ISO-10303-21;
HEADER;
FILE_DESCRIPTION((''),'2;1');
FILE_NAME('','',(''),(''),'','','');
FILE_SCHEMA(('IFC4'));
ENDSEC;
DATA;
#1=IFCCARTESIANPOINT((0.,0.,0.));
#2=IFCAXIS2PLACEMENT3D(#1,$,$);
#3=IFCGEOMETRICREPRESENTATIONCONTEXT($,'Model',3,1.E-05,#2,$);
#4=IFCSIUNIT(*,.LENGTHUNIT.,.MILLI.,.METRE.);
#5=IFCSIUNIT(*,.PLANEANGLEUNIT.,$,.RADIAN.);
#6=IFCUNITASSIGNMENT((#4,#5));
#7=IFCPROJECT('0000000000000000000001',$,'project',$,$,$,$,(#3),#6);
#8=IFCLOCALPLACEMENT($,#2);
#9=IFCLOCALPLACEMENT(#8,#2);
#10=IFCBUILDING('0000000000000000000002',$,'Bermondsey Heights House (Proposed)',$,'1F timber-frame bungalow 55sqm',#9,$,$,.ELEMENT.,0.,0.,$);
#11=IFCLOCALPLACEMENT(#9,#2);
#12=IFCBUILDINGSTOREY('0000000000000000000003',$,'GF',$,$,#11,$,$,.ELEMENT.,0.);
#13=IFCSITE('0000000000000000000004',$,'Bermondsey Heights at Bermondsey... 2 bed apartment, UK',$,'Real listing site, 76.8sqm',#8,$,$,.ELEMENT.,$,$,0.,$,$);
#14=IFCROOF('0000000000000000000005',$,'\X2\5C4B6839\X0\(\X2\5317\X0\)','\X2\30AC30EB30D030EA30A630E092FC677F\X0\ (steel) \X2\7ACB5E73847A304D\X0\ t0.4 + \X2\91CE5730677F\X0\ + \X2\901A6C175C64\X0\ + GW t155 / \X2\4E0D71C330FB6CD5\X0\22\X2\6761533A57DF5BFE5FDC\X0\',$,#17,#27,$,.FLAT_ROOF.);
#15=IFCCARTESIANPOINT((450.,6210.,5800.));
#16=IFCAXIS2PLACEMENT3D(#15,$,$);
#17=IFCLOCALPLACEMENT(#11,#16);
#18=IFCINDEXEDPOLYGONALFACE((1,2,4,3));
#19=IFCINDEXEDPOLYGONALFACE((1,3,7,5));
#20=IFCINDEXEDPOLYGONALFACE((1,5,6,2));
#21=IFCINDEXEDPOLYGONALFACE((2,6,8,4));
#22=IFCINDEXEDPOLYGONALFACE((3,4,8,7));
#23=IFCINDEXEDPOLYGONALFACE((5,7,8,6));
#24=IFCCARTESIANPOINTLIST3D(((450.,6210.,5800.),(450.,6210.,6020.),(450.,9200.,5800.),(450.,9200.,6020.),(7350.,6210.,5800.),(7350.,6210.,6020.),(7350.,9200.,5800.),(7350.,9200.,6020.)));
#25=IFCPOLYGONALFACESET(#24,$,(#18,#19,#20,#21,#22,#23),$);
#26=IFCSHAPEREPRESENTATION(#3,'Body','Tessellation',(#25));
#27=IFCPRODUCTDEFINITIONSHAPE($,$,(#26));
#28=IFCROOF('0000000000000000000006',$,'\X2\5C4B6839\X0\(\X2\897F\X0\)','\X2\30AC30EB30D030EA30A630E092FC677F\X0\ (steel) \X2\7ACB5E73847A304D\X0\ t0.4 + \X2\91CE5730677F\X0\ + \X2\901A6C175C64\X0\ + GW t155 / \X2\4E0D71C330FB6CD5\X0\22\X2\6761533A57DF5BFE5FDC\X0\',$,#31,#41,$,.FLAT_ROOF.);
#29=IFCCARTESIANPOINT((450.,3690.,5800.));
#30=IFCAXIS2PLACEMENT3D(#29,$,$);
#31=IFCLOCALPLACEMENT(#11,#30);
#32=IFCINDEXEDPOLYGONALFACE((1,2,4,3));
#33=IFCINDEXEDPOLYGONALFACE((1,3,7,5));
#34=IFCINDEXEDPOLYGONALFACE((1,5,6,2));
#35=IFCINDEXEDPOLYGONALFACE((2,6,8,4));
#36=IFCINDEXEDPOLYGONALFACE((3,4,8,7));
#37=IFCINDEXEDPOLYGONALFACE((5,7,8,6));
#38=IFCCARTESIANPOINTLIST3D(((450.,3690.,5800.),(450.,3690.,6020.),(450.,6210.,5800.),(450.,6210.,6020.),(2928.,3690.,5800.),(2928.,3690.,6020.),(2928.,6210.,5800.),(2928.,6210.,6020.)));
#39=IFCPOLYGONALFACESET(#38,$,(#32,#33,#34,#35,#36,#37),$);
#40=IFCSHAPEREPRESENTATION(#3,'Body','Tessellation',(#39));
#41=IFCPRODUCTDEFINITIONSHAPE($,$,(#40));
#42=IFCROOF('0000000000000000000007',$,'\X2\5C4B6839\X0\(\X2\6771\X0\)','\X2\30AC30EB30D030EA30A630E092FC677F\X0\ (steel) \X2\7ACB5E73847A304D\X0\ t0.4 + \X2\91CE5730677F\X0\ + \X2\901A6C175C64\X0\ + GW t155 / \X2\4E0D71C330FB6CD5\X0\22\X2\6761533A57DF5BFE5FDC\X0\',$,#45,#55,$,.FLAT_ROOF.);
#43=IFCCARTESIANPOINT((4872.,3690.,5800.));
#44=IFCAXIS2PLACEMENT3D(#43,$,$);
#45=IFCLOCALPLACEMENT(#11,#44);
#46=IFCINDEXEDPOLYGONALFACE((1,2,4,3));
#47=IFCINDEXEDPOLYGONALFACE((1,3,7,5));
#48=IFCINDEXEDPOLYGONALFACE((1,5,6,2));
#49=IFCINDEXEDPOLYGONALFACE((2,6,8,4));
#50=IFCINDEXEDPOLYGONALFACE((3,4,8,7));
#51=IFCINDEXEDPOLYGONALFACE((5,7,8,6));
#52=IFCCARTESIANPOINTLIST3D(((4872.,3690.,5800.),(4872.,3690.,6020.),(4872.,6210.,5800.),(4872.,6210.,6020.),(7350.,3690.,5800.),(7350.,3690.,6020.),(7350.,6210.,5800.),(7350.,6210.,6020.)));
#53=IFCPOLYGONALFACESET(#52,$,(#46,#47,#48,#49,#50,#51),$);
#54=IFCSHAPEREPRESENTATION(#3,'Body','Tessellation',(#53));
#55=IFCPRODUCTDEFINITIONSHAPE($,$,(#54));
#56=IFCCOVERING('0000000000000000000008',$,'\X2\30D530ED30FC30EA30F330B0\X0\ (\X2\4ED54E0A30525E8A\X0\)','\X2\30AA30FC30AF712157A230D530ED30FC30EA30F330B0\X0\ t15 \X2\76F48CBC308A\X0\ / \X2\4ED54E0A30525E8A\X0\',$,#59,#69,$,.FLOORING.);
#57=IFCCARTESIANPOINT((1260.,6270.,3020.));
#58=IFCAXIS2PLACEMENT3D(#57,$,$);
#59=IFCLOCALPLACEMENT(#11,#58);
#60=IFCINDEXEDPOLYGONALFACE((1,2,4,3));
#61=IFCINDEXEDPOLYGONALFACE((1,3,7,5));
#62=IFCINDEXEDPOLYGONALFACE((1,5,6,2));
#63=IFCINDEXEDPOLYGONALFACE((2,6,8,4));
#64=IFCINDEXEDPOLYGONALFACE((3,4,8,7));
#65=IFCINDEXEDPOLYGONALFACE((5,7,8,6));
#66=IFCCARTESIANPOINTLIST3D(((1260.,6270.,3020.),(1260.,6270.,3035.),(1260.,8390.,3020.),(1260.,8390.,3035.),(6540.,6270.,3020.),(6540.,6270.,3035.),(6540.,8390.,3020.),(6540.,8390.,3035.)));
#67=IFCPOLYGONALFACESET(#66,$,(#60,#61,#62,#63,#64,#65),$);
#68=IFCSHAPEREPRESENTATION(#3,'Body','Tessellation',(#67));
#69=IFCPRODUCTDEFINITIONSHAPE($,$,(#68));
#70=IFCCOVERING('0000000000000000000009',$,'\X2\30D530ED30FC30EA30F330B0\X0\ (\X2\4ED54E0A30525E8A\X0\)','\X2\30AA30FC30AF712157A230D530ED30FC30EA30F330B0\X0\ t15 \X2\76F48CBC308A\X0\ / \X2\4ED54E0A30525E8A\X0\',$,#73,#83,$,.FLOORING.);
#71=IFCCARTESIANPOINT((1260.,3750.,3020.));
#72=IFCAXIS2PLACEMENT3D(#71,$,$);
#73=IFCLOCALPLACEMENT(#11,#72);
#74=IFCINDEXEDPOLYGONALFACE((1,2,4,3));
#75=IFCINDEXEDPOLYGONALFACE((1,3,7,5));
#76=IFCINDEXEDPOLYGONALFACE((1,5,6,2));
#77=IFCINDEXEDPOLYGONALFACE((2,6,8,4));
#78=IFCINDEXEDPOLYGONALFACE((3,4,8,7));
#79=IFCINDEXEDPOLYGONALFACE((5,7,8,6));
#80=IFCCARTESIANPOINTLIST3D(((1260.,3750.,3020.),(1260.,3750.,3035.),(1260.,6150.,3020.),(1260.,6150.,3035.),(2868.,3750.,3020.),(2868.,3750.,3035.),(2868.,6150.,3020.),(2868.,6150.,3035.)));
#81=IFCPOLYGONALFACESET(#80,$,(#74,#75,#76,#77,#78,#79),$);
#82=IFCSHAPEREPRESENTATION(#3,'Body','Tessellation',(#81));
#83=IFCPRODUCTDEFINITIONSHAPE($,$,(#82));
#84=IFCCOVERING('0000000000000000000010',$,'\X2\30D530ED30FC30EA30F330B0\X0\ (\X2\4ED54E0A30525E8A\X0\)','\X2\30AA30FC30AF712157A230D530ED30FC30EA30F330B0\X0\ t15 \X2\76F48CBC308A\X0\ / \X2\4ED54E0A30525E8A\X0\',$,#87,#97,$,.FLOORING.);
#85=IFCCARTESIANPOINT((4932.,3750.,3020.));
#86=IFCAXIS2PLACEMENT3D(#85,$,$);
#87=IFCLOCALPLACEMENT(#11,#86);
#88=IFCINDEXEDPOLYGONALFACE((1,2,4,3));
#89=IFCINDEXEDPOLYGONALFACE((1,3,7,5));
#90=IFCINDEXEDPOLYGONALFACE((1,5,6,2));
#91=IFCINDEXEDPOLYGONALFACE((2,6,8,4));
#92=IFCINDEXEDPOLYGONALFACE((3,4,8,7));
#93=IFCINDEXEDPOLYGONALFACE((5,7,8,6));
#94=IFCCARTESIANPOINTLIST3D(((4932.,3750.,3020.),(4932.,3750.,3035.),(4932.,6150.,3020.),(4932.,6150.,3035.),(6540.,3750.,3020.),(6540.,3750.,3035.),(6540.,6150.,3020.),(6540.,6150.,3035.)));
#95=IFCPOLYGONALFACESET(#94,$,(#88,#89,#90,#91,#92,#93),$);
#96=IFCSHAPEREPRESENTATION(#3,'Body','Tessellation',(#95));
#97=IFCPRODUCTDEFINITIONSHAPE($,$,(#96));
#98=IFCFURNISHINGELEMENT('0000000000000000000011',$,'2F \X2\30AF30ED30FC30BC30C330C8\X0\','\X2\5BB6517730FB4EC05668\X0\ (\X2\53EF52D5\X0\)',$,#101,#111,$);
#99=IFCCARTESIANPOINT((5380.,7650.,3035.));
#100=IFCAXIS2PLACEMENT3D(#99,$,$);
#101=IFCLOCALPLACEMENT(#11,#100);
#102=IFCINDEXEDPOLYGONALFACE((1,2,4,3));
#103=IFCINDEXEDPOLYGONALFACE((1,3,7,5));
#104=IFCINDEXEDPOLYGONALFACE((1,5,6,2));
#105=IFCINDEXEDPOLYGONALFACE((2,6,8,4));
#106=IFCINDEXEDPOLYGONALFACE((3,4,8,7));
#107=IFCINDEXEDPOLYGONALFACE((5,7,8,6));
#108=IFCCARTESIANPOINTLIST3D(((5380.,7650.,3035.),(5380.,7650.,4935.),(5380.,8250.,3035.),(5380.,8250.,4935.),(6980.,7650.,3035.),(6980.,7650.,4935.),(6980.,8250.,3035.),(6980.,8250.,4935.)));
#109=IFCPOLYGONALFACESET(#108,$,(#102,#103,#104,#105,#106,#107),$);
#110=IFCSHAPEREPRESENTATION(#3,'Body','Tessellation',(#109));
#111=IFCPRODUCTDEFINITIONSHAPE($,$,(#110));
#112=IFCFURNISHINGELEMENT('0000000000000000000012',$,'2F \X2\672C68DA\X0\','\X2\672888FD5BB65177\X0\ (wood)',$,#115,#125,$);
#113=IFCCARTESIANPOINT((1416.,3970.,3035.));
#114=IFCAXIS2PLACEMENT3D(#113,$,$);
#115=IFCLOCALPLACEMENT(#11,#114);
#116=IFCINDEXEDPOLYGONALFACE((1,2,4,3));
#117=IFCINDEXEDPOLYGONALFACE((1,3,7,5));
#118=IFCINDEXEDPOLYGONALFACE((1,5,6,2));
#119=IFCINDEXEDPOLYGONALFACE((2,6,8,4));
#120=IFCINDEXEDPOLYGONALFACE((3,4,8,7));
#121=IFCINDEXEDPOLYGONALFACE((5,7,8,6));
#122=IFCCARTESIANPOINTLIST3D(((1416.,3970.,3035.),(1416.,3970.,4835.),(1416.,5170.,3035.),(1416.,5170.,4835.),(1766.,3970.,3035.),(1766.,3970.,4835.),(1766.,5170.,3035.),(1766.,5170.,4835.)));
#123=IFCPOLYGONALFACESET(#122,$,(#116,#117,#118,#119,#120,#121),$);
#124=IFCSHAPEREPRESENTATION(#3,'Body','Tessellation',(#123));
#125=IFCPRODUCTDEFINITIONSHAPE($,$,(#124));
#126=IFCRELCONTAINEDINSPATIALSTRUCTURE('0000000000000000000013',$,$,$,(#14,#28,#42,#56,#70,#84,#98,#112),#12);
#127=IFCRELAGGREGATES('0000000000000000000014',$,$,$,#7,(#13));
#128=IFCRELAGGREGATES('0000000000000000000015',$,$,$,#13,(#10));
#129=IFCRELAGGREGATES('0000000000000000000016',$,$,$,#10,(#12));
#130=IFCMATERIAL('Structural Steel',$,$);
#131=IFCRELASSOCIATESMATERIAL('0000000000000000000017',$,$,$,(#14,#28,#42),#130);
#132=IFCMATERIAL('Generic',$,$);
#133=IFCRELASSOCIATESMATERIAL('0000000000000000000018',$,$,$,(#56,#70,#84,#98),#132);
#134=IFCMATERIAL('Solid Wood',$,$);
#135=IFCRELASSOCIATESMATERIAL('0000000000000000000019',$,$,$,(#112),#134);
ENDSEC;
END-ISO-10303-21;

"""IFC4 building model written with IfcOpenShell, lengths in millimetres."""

from ifc_helpers import new_model, si_unit, frame, frame_2d, origin, place, context, project, spatial, rectangle, extrude, material, element, save


model = new_model("IFC4")

# Units and contexts
model_context = context("Model", 3, precision=1e-05, world=origin())
ifc_project = project(units=[si_unit("LENGTHUNIT", "METRE", prefix="MILLI"), si_unit("PLANEANGLEUNIT", "RADIAN")], contexts=[model_context])

# Site, building, storey
site_placement = place(None, origin())
site = spatial("IfcSite", under=ifc_project, at=site_placement, Name="Bermondsey Heights at Bermondsey... 2 bed apartment, UK", ObjectType="Real listing site, 76.8sqm", CompositionType="ELEMENT", RefElevation=0.0)
building_placement = place(site_placement, origin())
building = spatial("IfcBuilding", under=site, at=building_placement, Name="Bermondsey Heights House (Proposed)", ObjectType="1F timber-frame bungalow 55sqm", CompositionType="ELEMENT", ElevationOfRefHeight=0.0, ElevationOfTerrain=0.0)
storey_placement = place(building_placement, origin())
storey = spatial("IfcBuildingStorey", under=building, at=storey_placement, Name="GF", CompositionType="ELEMENT", Elevation=0.0)

# Shared definitions
ifc_material_1 = material(Name="Solid Wood")

# Shared definitions
ifc_material_2 = material(Name="Generic")

# Roofs
ifc_material_3 = material(Name="Structural Steel")
for number, where, name in (
    (1, (450.0, 6210.0, 5800.0), "屋根(北)"),
):
    element("IfcRoof", number, at=place(storey_placement, frame(where)), inside=storey, material=ifc_material_3, Name=name, Description="ガルバリウム鋼板 (steel) 立平葺き t0.4 + 野地板 + 通気層 + GW t155 / 不燃・法22条区域対応", PredefinedType="FLAT_ROOF", context=model_context, shape_type="SweptSolid", body=[
        extrude(rectangle(XDim=6900.0, YDim=2990.0, at=frame_2d((3450.0, 1495.0))), frame((450.0, 6210.0, 5800.0)), (0.0, 0.0, 1.0), 220.0),
    ])
roof_1_placement = place(storey_placement, frame((450.0, 3690.0, 5800.0)))
element("IfcRoof", 2, at=roof_1_placement, inside=storey, material=ifc_material_3, Name="屋根(西)", Description="ガルバリウム鋼板 (steel) 立平葺き t0.4 + 野地板 + 通気層 + GW t155 / 不燃・法22条区域対応", PredefinedType="FLAT_ROOF", context=model_context, shape_type="SweptSolid", body=[
    extrude(rectangle(XDim=2478.0, YDim=2520.0, at=frame_2d((1239.0, 1260.0))), frame((450.0, 3690.0, 5800.0)), (0.0, 0.0, 1.0), 220.0),
])
roof_2_placement = place(storey_placement, frame((4872.0, 3690.0, 5800.0)))
element("IfcRoof", 3, at=roof_2_placement, inside=storey, material=ifc_material_3, Name="屋根(東)", Description="ガルバリウム鋼板 (steel) 立平葺き t0.4 + 野地板 + 通気層 + GW t155 / 不燃・法22条区域対応", PredefinedType="FLAT_ROOF", context=model_context, shape_type="SweptSolid", body=[
    extrude(rectangle(XDim=2478.0, YDim=2520.0, at=frame_2d((1239.0, 1260.0))), frame((4872.0, 3690.0, 5800.0)), (0.0, 0.0, 1.0), 220.0),
])

# Coverings
covering_1_placement = place(storey_placement, frame((1260.0, 6270.0, 3020.0)))
element("IfcCovering", 4, at=covering_1_placement, inside=storey, material=ifc_material_2, Name="フローリング (仕上げ床)", Description="オーク無垢フローリング t15 直貼り / 仕上げ床", PredefinedType="FLOORING", context=model_context, shape_type="SweptSolid", body=[
    extrude(rectangle(XDim=5280.0, YDim=2120.0, at=frame_2d((2640.0, 1060.0))), frame((1260.0, 6270.0, 3020.0)), (0.0, 0.0, 1.0), 15.0),
])
covering_2_placement = place(storey_placement, frame((1260.0, 3750.0, 3020.0)))
element("IfcCovering", 5, at=covering_2_placement, inside=storey, material=ifc_material_2, Name="フローリング (仕上げ床)", Description="オーク無垢フローリング t15 直貼り / 仕上げ床", PredefinedType="FLOORING", context=model_context, shape_type="SweptSolid", body=[
    extrude(rectangle(XDim=1608.0, YDim=2400.0, at=frame_2d((804.0, 1200.0))), frame((1260.0, 3750.0, 3020.0)), (0.0, 0.0, 1.0), 15.0),
])
covering_3_placement = place(storey_placement, frame((4932.0, 3750.0, 3020.0)))
element("IfcCovering", 6, at=covering_3_placement, inside=storey, material=ifc_material_2, Name="フローリング (仕上げ床)", Description="オーク無垢フローリング t15 直貼り / 仕上げ床", PredefinedType="FLOORING", context=model_context, shape_type="SweptSolid", body=[
    extrude(rectangle(XDim=1608.0, YDim=2400.0, at=frame_2d((804.0, 1200.0))), frame((4932.0, 3750.0, 3020.0)), (0.0, 0.0, 1.0), 15.0),
])

# Furnishing elements
furnishing_1_placement = place(storey_placement, frame((5380.0, 7650.0, 3035.0)))
element("IfcFurnishingElement", 7, at=furnishing_1_placement, inside=storey, material=ifc_material_2, Name="2F クローゼット", Description="家具・什器 (可動)", context=model_context, shape_type="SweptSolid", body=[
    extrude(rectangle(XDim=1600.0, YDim=600.0, at=frame_2d((800.0, 300.0))), frame((5380.0, 7650.0, 3035.0)), (0.0, 0.0, 1.0), 1900.0),
])
furnishing_2_placement = place(storey_placement, frame((1416.0, 3970.0, 3035.0)))
element("IfcFurnishingElement", 8, at=furnishing_2_placement, inside=storey, material=ifc_material_1, Name="2F 本棚", Description="木製家具 (wood)", context=model_context, shape_type="SweptSolid", body=[
    extrude(rectangle(XDim=350.0, YDim=1200.0, at=frame_2d((175.0, 600.0))), frame((1416.0, 3970.0, 3035.0)), (0.0, 0.0, 1.0), 1800.0),
])

save(model, "model.ifc")
